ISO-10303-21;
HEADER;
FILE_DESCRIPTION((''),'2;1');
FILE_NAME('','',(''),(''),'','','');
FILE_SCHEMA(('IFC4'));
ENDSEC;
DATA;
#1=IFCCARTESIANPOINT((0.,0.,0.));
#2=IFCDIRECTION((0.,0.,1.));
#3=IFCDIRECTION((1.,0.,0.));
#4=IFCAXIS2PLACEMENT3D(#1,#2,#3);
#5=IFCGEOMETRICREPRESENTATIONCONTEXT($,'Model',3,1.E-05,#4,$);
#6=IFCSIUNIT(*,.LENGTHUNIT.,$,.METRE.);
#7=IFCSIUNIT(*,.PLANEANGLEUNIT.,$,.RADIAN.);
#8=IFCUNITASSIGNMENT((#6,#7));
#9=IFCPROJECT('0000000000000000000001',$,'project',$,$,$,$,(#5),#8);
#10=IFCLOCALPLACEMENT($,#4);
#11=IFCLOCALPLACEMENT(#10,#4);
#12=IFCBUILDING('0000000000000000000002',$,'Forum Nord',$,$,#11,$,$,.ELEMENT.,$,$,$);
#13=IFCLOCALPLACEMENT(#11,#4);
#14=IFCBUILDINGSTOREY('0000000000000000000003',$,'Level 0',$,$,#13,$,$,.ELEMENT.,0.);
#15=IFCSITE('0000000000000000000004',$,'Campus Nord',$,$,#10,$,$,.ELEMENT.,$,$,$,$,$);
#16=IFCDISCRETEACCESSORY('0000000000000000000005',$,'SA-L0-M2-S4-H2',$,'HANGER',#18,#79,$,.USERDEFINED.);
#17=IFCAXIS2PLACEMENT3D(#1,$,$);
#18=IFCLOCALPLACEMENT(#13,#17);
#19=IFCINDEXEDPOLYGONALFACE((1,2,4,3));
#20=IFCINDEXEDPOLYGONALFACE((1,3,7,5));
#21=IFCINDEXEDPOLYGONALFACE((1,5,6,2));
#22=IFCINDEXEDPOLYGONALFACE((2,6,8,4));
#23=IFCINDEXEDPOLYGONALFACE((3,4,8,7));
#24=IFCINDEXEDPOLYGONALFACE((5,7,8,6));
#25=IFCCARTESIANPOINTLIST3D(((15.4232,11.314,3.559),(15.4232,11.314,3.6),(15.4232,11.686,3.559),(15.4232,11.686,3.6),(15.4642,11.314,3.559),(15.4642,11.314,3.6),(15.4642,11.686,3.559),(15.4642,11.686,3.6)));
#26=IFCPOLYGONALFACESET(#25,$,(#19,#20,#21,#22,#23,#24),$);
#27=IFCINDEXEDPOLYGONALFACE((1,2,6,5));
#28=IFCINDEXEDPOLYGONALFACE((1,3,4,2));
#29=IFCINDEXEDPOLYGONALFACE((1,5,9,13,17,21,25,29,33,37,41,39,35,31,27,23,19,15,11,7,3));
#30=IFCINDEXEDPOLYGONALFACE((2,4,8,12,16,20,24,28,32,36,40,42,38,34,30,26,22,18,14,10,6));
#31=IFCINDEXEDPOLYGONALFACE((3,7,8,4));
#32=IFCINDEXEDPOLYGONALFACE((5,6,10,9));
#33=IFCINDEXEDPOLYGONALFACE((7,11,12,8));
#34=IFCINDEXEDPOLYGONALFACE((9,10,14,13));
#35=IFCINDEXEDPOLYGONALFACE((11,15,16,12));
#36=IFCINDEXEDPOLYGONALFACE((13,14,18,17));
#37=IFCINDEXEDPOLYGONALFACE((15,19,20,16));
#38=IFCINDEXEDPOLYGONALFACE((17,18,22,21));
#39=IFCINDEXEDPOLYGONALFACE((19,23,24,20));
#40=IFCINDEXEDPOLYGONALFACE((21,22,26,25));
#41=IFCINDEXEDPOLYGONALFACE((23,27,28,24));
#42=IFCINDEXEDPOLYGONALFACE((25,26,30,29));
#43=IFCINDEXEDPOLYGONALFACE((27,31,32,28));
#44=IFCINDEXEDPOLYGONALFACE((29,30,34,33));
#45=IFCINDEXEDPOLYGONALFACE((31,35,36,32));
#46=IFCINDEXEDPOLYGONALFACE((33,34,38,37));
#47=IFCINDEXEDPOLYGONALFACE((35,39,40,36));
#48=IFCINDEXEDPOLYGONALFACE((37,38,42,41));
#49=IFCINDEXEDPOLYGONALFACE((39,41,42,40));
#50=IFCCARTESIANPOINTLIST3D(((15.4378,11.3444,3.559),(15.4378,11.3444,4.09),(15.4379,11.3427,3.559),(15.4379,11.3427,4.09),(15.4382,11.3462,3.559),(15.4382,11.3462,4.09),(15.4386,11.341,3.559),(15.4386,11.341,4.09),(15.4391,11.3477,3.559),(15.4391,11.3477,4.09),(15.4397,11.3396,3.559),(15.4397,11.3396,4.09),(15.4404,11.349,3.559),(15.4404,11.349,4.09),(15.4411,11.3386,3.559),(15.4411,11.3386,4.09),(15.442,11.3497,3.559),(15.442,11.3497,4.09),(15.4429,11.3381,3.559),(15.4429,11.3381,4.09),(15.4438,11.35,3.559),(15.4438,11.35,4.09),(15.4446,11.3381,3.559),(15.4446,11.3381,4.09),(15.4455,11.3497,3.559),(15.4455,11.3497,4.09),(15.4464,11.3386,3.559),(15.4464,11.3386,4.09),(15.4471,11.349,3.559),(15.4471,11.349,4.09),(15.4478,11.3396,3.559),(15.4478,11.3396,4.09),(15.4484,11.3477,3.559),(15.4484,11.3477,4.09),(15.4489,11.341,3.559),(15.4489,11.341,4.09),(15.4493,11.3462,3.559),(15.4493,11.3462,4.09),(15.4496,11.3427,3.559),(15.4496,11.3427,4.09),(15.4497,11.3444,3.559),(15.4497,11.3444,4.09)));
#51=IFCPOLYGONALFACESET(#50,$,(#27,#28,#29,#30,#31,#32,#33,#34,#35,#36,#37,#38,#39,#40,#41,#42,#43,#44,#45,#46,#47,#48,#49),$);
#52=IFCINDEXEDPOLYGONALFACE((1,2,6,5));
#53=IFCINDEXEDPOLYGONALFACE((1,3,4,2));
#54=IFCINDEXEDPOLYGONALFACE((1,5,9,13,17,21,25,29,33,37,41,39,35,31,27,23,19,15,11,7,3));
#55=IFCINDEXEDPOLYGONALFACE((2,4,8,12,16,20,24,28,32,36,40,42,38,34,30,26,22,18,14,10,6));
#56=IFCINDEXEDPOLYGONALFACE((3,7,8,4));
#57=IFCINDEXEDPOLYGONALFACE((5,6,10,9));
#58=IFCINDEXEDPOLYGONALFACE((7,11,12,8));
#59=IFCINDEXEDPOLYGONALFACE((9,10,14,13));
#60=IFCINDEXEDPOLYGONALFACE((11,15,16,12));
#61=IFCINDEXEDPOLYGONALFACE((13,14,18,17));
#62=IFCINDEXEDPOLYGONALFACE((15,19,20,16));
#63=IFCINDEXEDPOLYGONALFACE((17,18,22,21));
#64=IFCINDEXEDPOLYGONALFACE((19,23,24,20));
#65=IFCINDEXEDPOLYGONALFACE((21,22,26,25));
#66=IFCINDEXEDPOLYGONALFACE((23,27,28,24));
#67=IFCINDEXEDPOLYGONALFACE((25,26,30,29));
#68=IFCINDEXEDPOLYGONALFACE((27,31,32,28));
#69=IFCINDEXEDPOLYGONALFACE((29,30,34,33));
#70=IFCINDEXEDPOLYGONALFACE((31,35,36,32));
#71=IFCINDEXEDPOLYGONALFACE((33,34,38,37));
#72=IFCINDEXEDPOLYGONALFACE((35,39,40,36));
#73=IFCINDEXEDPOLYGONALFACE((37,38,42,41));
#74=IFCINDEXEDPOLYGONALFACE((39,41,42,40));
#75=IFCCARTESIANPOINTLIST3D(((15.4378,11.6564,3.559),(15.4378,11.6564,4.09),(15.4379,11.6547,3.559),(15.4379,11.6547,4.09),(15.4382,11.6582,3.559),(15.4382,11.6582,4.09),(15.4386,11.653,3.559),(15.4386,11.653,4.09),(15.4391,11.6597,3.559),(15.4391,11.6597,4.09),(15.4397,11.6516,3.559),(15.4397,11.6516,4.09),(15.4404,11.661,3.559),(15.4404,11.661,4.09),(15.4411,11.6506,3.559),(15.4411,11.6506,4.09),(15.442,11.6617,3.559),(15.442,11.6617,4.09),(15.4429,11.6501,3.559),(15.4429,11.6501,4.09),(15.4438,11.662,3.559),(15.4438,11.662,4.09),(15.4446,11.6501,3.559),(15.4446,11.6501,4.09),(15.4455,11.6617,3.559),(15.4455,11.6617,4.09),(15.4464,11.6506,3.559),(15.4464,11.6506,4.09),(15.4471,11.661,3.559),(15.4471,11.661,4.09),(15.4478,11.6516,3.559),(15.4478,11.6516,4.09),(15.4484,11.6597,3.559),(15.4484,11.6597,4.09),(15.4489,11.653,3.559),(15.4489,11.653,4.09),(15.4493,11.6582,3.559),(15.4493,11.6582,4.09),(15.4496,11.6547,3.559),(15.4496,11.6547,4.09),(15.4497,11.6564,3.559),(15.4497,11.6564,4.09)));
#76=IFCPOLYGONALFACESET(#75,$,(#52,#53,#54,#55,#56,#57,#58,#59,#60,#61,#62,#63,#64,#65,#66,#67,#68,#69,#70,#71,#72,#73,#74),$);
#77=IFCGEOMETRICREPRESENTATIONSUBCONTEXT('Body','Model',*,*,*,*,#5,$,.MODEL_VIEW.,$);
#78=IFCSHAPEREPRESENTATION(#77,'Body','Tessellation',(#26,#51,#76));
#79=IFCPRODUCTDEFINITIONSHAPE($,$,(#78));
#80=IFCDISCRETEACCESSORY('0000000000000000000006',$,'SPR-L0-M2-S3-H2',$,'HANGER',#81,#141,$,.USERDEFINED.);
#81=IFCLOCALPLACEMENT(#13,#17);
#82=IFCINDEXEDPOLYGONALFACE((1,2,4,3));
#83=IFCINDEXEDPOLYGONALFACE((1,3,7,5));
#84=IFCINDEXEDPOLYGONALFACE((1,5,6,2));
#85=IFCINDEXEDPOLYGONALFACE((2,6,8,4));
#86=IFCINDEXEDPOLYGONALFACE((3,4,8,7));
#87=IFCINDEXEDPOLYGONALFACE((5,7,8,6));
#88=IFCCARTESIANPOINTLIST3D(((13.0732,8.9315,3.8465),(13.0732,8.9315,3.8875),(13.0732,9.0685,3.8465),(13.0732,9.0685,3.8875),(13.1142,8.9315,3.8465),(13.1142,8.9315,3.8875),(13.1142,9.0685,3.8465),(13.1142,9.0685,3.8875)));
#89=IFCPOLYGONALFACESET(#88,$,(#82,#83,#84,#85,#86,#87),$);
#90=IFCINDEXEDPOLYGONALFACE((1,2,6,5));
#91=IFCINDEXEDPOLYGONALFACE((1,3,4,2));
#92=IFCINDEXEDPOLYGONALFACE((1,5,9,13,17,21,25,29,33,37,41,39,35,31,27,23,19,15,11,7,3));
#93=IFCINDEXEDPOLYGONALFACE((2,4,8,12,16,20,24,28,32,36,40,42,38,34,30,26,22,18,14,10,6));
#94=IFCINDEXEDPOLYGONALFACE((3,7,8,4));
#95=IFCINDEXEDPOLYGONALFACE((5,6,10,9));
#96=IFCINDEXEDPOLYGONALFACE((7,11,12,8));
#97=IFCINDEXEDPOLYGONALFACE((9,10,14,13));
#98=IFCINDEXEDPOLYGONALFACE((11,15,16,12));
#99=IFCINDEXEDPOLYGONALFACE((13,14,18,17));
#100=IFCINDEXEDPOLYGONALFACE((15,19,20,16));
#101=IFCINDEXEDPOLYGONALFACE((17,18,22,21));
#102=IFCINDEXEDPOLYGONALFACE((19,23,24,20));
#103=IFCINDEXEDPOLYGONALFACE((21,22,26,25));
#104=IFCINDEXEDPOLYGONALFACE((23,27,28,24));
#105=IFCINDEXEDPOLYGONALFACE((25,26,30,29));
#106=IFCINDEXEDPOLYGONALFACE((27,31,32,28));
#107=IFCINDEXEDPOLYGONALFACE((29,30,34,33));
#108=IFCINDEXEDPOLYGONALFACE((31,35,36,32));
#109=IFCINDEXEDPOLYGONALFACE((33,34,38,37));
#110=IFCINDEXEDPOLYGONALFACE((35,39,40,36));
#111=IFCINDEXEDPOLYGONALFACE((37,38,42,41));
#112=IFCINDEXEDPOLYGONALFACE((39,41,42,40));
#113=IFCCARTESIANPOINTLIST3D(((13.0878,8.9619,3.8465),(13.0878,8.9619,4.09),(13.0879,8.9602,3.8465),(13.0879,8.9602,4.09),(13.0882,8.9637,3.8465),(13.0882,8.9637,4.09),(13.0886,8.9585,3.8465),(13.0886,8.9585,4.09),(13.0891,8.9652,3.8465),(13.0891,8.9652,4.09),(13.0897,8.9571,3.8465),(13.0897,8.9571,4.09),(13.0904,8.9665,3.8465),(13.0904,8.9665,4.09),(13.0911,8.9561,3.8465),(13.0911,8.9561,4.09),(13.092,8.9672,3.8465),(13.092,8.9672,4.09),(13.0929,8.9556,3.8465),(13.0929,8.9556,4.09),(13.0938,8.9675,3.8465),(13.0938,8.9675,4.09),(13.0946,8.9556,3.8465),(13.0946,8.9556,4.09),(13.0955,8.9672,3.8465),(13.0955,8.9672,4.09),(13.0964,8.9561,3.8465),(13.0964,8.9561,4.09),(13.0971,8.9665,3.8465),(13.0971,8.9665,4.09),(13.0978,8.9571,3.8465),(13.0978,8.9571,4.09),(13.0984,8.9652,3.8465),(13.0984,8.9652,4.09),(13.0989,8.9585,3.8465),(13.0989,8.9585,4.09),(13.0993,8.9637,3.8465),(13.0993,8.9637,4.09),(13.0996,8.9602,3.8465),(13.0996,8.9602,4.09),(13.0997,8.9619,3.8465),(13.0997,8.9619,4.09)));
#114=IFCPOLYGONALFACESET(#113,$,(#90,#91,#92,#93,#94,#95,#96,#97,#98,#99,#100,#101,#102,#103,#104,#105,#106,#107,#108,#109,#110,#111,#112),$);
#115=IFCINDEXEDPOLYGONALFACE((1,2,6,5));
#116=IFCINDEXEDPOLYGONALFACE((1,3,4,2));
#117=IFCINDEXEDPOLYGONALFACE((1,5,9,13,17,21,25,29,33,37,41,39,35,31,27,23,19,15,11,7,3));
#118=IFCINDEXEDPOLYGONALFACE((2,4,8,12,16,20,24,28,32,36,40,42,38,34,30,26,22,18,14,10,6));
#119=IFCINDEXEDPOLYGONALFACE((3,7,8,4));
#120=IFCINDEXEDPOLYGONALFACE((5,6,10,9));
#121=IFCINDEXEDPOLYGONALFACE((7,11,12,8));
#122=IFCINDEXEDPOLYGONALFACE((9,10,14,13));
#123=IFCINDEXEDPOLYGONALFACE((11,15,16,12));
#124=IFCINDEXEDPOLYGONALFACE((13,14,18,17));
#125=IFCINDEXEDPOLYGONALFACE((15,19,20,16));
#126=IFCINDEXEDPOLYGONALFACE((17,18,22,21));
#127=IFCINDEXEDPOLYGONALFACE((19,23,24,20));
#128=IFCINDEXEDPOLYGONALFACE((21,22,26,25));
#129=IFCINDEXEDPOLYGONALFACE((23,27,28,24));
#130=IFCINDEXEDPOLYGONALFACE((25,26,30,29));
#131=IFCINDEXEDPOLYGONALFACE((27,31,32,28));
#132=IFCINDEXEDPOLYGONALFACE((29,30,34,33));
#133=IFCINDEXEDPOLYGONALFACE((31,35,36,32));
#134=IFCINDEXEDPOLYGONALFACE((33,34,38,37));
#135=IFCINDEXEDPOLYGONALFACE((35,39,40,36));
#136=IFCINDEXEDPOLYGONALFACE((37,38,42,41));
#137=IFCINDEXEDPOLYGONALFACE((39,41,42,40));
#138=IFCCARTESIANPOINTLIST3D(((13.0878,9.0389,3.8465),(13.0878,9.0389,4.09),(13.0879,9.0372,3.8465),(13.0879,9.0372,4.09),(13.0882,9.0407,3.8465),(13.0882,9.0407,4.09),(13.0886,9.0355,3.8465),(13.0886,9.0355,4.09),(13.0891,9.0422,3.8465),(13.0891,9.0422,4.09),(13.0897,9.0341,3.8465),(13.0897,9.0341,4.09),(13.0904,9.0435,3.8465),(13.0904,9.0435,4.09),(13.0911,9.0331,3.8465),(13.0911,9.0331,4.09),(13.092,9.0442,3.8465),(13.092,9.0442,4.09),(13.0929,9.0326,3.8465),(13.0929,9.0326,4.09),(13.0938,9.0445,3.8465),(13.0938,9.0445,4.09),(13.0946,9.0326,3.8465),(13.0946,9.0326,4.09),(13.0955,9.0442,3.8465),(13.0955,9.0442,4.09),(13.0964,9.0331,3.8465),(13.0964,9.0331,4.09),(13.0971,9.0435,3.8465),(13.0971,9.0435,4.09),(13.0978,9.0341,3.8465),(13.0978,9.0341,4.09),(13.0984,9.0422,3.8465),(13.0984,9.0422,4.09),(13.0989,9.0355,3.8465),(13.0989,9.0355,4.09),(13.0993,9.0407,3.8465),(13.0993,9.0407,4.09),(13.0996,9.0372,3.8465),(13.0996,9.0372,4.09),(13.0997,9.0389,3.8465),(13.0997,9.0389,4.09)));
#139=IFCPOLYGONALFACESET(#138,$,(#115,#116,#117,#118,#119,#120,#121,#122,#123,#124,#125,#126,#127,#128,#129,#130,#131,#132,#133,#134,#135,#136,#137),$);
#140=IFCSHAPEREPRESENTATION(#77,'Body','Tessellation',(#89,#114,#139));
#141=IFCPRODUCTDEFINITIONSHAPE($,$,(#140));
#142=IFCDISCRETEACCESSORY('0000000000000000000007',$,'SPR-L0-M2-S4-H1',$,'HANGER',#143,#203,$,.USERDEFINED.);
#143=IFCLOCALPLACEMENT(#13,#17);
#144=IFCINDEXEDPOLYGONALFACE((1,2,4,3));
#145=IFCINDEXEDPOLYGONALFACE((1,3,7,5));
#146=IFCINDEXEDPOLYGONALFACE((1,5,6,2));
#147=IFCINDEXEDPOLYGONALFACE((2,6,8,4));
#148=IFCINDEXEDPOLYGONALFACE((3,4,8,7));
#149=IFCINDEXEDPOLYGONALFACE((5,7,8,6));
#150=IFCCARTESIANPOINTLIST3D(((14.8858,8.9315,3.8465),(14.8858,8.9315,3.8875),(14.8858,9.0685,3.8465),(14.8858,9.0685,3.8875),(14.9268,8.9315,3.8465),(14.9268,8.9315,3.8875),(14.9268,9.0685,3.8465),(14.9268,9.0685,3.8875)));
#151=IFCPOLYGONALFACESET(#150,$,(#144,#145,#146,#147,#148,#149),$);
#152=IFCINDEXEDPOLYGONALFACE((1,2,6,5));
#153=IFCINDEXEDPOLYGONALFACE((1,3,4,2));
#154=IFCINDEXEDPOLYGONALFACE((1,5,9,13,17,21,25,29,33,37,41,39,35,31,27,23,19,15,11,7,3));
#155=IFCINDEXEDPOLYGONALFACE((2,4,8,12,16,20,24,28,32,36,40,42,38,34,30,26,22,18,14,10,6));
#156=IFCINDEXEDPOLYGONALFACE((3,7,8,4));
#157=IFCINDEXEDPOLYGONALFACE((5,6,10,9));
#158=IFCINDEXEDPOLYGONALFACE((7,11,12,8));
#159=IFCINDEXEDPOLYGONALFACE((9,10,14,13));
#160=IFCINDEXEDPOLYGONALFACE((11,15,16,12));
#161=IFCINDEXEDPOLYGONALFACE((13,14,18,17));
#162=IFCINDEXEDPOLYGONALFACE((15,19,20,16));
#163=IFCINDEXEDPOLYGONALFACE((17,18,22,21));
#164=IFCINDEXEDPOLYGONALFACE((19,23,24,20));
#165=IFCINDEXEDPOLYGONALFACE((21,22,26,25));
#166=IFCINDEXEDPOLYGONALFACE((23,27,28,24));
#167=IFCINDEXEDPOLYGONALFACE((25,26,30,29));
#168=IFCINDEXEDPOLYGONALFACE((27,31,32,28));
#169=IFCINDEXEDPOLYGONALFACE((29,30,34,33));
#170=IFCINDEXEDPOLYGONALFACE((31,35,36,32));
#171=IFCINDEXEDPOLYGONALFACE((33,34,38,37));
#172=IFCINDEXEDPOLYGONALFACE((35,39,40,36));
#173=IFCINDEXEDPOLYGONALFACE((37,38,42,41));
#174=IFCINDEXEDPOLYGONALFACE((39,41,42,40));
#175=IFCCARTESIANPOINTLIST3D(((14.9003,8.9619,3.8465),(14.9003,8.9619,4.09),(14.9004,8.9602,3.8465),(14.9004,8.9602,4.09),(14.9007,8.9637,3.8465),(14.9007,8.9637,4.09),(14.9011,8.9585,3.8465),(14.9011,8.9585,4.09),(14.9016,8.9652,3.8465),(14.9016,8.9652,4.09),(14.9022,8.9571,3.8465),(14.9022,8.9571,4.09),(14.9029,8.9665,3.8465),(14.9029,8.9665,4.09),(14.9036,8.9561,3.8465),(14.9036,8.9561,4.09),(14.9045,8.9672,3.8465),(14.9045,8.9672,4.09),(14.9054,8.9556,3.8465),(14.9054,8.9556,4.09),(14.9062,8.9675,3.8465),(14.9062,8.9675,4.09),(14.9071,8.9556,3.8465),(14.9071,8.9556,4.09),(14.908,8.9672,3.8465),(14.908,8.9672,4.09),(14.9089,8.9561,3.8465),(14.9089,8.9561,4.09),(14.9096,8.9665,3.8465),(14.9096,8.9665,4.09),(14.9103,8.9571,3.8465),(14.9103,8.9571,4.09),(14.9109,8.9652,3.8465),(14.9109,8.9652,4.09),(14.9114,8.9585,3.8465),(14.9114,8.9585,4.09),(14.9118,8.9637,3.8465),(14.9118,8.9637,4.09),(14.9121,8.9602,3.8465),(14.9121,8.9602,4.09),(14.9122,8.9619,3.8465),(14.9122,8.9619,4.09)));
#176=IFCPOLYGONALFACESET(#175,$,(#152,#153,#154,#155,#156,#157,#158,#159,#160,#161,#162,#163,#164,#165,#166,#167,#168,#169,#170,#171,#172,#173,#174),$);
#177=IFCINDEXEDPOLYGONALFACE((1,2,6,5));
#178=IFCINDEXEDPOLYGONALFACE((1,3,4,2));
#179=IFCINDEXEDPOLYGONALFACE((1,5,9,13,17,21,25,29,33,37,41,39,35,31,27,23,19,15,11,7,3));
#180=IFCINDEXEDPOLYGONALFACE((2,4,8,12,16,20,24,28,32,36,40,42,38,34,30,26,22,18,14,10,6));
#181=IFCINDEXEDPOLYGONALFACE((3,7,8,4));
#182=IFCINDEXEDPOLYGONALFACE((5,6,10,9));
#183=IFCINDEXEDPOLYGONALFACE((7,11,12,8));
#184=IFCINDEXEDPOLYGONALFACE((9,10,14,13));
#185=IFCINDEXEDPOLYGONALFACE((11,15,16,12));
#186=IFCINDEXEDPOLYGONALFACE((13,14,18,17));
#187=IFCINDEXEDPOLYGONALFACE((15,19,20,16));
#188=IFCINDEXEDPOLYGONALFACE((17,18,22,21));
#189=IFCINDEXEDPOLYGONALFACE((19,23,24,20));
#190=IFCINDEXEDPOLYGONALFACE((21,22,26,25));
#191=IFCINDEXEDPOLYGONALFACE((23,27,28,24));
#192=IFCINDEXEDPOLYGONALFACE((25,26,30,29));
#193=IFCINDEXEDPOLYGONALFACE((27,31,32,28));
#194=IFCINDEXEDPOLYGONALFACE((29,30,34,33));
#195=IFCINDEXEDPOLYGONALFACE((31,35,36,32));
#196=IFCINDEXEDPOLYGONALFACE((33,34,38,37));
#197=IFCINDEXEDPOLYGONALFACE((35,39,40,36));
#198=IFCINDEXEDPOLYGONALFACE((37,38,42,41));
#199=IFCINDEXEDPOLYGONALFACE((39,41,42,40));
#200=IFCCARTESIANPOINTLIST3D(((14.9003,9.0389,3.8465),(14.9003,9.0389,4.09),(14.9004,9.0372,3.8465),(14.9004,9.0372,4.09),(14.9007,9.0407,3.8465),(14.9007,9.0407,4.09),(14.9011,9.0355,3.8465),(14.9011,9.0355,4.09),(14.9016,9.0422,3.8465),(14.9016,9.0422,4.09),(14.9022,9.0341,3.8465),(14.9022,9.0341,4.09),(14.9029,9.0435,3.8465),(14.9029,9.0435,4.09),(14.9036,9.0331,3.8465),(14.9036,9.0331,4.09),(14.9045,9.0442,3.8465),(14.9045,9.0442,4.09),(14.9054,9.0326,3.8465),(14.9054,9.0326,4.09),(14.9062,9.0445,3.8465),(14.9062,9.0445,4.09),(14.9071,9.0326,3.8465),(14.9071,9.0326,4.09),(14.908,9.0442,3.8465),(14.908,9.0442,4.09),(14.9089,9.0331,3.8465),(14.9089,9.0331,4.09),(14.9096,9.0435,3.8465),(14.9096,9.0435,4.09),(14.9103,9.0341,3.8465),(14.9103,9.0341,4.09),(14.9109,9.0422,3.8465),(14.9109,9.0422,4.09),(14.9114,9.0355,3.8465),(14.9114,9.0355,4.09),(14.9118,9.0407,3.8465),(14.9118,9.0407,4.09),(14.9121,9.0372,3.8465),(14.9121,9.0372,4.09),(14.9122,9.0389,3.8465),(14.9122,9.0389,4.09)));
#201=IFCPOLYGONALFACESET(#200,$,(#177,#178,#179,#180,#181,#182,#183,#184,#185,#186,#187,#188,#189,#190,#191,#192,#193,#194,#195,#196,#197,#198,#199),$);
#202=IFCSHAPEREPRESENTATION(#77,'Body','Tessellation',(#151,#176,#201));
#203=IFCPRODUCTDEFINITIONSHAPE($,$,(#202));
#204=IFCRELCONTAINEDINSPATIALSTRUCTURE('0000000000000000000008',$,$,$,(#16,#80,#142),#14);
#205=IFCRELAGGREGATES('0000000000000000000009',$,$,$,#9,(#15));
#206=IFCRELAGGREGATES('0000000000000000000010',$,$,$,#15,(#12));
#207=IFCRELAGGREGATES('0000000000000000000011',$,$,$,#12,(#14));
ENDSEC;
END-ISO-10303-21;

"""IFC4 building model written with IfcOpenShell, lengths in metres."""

from ifc_helpers import new_model, si_unit, frame, frame_2d, origin_with_axes, origin_2d_with_axis, place, context, subcontext, project, spatial, rectangle, circle, extrude, element, save


model = new_model("IFC4")

# Units and contexts
model_context = context("Model", 3, precision=1e-05, world=origin_with_axes())
body_context = subcontext(model_context, "Body", "Model", "MODEL_VIEW")
ifc_project = project(units=[si_unit("LENGTHUNIT", "METRE"), si_unit("PLANEANGLEUNIT", "RADIAN")], contexts=[model_context])

# Site, building, storey
site_placement = place(None, origin_with_axes())
site = spatial("IfcSite", under=ifc_project, at=site_placement, Name="Campus Nord", CompositionType="ELEMENT")
building_placement = place(site_placement, origin_with_axes())
building = spatial("IfcBuilding", under=site, at=building_placement, Name="Forum Nord", CompositionType="ELEMENT")
storey_placement = place(building_placement, origin_with_axes())
storey = spatial("IfcBuildingStorey", under=building, at=storey_placement, Name="Level 0", CompositionType="ELEMENT", Elevation=0.0)

# Discrete accessories
for number, where, z_axis, x_axis, name in (
    (1, (15.4437, 11.5, 3.6), (0.0, 0.0, 1.0), (0.0, 1.0, 0.0), "SA-L0-M2-S4-H2"),
):
    element("IfcDiscreteAccessory", number, at=place(storey_placement, frame(where, z_axis=z_axis, x_axis=x_axis)), inside=storey, Name=name, ObjectType="HANGER", PredefinedType="USERDEFINED", context=body_context, shape_type="SweptSolid", body=[
        extrude(rectangle(XDim=0.372, YDim=0.041, at=origin_2d_with_axis()), frame((0.0, 0.0, -0.041), z_axis=(0.0, 0.0, 1.0), x_axis=(1.0, 0.0, 0.0)), (0.0, 0.0, 1.0), 0.041),
        extrude(circle(Radius=0.006, at=frame_2d((-0.156, 0.0), x_axis=(1.0, 0.0))), frame((0.0, 0.0, -0.041), z_axis=(0.0, 0.0, 1.0), x_axis=(1.0, 0.0, 0.0)), (0.0, 0.0, 1.0), 0.531),
        extrude(circle(Radius=0.006, at=frame_2d((0.156, 0.0), x_axis=(1.0, 0.0))), frame((0.0, 0.0, -0.041), z_axis=(0.0, 0.0, 1.0), x_axis=(1.0, 0.0, 0.0)), (0.0, 0.0, 1.0), 0.531),
    ])
for number, where, z_axis, x_axis, name in (
    (2, (13.0938, 9.0, 3.8875), (0.0, 0.0, 1.0), (0.0, 1.0, 0.0), "SPR-L0-M2-S3-H2"),
    (3, (14.9062, 9.0, 3.8875), (0.0, 0.0, 1.0), (0.0, 1.0, 0.0), "SPR-L0-M2-S4-H1"),
):
    element("IfcDiscreteAccessory", number, at=place(storey_placement, frame(where, z_axis=z_axis, x_axis=x_axis)), inside=storey, Name=name, ObjectType="HANGER", PredefinedType="USERDEFINED", context=body_context, shape_type="SweptSolid", body=[
        extrude(rectangle(XDim=0.137, YDim=0.041, at=origin_2d_with_axis()), frame((0.0, 0.0, -0.041), z_axis=(0.0, 0.0, 1.0), x_axis=(1.0, 0.0, 0.0)), (0.0, 0.0, 1.0), 0.041),
        extrude(circle(Radius=0.006, at=frame_2d((-0.0385, 0.0), x_axis=(1.0, 0.0))), frame((0.0, 0.0, -0.041), z_axis=(0.0, 0.0, 1.0), x_axis=(1.0, 0.0, 0.0)), (0.0, 0.0, 1.0), 0.2435),
        extrude(circle(Radius=0.006, at=frame_2d((0.0385, 0.0), x_axis=(1.0, 0.0))), frame((0.0, 0.0, -0.041), z_axis=(0.0, 0.0, 1.0), x_axis=(1.0, 0.0, 0.0)), (0.0, 0.0, 1.0), 0.2435),
    ])

save(model, "model.ifc")
